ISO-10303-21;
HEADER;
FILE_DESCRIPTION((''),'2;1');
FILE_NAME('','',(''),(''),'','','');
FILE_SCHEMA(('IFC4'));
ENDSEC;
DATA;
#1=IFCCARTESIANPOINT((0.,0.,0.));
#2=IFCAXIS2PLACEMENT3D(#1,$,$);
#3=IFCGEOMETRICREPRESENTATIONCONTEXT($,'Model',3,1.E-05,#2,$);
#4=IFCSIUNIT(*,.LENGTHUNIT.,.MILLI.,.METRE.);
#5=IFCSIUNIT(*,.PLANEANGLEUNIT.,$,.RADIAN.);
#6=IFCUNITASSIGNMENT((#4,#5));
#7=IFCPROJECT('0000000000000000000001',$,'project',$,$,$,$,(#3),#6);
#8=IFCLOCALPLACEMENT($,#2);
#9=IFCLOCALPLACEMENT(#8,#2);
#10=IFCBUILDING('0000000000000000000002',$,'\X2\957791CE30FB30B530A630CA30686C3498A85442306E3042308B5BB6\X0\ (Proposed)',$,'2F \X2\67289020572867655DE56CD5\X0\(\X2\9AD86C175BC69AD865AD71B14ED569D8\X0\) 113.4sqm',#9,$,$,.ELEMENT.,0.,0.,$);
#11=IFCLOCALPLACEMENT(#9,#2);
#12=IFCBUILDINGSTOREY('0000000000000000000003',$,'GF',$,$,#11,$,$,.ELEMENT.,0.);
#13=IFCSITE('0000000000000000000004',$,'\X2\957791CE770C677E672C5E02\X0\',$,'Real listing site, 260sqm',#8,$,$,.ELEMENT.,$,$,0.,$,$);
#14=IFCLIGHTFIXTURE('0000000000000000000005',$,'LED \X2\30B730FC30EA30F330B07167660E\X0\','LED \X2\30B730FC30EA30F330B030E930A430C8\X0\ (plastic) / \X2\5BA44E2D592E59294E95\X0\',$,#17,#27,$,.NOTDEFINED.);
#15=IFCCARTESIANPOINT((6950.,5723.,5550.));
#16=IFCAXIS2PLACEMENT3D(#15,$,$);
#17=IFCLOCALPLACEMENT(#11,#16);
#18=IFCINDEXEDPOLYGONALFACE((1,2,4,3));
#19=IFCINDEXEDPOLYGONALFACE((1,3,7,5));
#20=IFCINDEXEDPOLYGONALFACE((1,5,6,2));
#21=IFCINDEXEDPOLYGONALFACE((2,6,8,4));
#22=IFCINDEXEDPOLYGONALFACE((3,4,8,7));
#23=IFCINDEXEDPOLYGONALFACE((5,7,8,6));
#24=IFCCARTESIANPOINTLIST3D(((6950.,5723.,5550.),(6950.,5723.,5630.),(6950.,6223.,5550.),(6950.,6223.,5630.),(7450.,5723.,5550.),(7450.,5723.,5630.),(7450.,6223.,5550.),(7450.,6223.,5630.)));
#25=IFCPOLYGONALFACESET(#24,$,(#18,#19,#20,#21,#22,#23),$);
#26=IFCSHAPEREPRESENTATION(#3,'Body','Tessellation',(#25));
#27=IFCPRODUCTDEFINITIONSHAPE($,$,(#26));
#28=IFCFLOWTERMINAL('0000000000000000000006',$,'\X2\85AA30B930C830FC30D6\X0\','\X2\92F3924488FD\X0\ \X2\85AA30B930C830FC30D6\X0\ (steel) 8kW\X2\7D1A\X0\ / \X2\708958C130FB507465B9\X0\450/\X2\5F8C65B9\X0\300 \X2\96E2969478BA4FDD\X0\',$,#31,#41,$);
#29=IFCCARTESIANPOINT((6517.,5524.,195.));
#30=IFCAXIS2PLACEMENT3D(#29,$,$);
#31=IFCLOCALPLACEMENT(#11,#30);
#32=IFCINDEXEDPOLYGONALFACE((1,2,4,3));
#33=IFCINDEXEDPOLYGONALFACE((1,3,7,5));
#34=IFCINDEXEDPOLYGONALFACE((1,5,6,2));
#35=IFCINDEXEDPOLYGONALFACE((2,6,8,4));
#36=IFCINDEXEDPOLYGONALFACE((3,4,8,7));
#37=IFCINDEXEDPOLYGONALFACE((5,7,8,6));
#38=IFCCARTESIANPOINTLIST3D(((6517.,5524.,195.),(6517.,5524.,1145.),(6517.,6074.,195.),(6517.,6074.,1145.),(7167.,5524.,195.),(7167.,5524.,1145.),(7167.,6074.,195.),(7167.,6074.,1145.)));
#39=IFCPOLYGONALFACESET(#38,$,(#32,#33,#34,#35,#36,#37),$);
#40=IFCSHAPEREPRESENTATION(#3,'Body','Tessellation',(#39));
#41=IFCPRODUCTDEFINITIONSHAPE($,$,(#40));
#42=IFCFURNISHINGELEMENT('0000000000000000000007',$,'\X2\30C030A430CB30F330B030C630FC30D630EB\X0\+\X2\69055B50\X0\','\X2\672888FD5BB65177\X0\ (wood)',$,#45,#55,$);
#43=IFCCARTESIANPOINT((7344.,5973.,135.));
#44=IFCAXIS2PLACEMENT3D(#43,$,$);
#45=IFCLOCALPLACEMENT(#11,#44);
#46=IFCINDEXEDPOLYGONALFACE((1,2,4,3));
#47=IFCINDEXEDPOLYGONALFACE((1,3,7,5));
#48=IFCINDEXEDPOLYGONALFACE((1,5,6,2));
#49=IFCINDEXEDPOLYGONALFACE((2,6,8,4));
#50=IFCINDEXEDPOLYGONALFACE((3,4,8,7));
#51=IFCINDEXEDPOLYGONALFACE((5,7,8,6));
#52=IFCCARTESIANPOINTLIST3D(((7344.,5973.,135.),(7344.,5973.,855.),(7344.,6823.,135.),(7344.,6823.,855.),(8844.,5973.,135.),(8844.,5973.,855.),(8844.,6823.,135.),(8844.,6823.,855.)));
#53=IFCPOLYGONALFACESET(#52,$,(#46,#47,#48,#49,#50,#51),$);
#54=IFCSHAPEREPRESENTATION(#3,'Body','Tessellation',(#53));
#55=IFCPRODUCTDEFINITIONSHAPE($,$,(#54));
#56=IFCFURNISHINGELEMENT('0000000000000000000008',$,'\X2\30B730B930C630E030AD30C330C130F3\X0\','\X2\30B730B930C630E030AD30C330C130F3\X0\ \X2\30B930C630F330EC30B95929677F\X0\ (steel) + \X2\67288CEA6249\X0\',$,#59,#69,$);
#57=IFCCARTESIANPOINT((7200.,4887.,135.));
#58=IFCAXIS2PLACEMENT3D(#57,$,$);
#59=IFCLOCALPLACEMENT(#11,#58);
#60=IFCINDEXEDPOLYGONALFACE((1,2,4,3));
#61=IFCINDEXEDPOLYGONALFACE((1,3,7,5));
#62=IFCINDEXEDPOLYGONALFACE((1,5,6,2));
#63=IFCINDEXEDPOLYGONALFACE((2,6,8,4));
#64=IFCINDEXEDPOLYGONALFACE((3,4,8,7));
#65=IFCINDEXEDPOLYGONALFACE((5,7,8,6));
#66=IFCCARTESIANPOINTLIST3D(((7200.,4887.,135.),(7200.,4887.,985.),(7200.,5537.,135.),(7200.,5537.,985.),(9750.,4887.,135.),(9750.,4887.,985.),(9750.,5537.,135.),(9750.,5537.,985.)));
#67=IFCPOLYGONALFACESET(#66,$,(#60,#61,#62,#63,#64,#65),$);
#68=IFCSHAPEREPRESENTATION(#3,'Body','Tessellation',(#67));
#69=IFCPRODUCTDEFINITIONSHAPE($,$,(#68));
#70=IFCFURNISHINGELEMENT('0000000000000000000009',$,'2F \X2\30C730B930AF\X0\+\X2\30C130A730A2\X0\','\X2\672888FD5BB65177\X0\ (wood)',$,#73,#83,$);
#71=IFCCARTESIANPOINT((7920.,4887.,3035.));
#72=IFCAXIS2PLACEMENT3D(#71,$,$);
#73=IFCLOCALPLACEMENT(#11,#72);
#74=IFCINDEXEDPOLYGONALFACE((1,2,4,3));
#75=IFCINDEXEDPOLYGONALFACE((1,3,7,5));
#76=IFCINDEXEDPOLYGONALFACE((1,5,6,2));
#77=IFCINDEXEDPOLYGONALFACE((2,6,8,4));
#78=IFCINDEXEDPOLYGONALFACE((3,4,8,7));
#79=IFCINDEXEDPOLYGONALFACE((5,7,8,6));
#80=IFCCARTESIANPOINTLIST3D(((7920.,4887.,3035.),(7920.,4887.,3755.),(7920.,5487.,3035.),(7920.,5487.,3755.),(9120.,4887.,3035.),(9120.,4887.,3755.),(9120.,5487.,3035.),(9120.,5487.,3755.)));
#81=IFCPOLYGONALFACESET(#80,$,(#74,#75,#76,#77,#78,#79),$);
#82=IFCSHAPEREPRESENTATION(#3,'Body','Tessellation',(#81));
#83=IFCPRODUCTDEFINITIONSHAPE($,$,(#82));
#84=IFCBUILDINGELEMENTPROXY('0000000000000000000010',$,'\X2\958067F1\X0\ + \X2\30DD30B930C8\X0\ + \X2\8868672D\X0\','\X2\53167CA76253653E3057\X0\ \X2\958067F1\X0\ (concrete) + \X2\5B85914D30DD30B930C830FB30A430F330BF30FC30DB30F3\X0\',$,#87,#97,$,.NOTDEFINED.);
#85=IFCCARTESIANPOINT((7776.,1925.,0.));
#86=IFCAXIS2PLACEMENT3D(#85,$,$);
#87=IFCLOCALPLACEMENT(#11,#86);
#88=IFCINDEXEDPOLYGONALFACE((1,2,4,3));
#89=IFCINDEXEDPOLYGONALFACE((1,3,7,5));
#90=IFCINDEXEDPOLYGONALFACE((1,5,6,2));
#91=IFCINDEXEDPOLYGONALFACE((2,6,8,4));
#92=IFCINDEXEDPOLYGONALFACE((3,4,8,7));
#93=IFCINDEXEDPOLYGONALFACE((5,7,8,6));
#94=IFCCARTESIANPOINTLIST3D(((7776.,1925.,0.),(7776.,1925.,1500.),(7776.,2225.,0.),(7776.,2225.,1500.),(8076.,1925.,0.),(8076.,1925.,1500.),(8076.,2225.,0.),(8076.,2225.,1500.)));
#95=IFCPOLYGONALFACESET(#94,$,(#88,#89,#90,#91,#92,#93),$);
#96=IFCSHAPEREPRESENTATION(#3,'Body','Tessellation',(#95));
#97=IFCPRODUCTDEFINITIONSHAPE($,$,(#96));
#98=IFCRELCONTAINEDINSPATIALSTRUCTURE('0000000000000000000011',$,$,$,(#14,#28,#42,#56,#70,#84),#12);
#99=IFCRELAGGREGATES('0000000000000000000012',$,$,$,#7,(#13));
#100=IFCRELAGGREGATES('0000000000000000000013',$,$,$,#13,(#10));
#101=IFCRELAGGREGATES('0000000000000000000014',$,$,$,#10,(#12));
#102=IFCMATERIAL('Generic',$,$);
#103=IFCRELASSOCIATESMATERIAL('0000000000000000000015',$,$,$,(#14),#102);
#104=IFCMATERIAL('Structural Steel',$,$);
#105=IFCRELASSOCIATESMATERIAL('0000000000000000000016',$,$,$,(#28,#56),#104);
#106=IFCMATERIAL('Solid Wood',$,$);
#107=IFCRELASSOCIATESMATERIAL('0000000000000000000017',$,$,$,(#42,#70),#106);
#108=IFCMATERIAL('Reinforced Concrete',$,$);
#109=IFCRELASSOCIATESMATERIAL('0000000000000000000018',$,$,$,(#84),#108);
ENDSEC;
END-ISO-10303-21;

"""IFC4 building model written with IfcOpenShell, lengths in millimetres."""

from ifc_helpers import new_model, si_unit, frame, frame_2d, origin, place, context, project, spatial, rectangle, extrude, material, element, save


model = new_model("IFC4")

# Units and contexts
model_context = context("Model", 3, precision=1e-05, world=origin())
ifc_project = project(units=[si_unit("LENGTHUNIT", "METRE", prefix="MILLI"), si_unit("PLANEANGLEUNIT", "RADIAN")], contexts=[model_context])

# Site, building, storey
site_placement = place(None, origin())
site = spatial("IfcSite", under=ifc_project, at=site_placement, Name="長野県松本市", ObjectType="Real listing site, 260sqm", CompositionType="ELEMENT", RefElevation=0.0)
building_placement = place(site_placement, origin())
building = spatial("IfcBuilding", under=site, at=building_placement, Name="長野・サウナと水風呂のある家 (Proposed)", ObjectType="2F 木造在来工法(高気密高断熱仕様) 113.4sqm", CompositionType="ELEMENT", ElevationOfRefHeight=0.0, ElevationOfTerrain=0.0)
storey_placement = place(building_placement, origin())
storey = spatial("IfcBuildingStorey", under=building, at=storey_placement, Name="GF", CompositionType="ELEMENT", Elevation=0.0)

# Shared definitions
ifc_material_1 = material(Name="Solid Wood")

# Shared definitions
ifc_material_2 = material(Name="Structural Steel")

# Shared definitions
ifc_material_3 = material(Name="Reinforced Concrete")

# Shared definitions
ifc_material_4 = material(Name="Generic")

# Light fixture
light_fixture_1_placement = place(storey_placement, frame((6950.0, 5723.0, 5550.0)))
element("IfcLightFixture", 1, at=light_fixture_1_placement, inside=storey, material=ifc_material_4, Name="LED シーリング照明", Description="LED シーリングライト (plastic) / 室中央天井", PredefinedType="NOTDEFINED", context=model_context, shape_type="SweptSolid", body=[
    extrude(rectangle(XDim=500.0, YDim=500.0, at=frame_2d((250.0, 250.0))), frame((6950.0, 5723.0, 5550.0)), (0.0, 0.0, 1.0), 80.0),
])

# Flow terminal
flow_terminal_1_placement = place(storey_placement, frame((6517.0, 5524.0, 195.0)))
element("IfcFlowTerminal", 2, at=flow_terminal_1_placement, inside=storey, material=ifc_material_2, Name="薪ストーブ", Description="鋳鉄製 薪ストーブ (steel) 8kW級 / 炉壁・側方450/後方300 離隔確保", context=model_context, shape_type="SweptSolid", body=[
    extrude(rectangle(XDim=650.0, YDim=550.0, at=frame_2d((325.0, 275.0))), frame((6517.0, 5524.0, 195.0)), (0.0, 0.0, 1.0), 950.0),
])

# Furnishing elements
furnishing_1_placement = place(storey_placement, frame((7344.0, 5973.0, 135.0)))
element("IfcFurnishingElement", 3, at=furnishing_1_placement, inside=storey, material=ifc_material_1, Name="ダイニングテーブル+椅子", Description="木製家具 (wood)", context=model_context, shape_type="SweptSolid", body=[
    extrude(rectangle(XDim=1500.0, YDim=850.0, at=frame_2d((750.0, 425.0))), frame((7344.0, 5973.0, 135.0)), (0.0, 0.0, 1.0), 720.0),
])
furnishing_2_placement = place(storey_placement, frame((7200.0, 4887.0, 135.0)))
element("IfcFurnishingElement", 4, at=furnishing_2_placement, inside=storey, material=ifc_material_2, Name="システムキッチン", Description="システムキッチン ステンレス天板 (steel) + 木質扉", context=model_context, shape_type="SweptSolid", body=[
    extrude(rectangle(XDim=2550.0, YDim=650.0, at=frame_2d((1275.0, 325.0))), frame((7200.0, 4887.0, 135.0)), (0.0, 0.0, 1.0), 850.0),
])
furnishing_3_placement = place(storey_placement, frame((7920.0, 4887.0, 3035.0)))
element("IfcFurnishingElement", 5, at=furnishing_3_placement, inside=storey, material=ifc_material_1, Name="2F デスク+チェア", Description="木製家具 (wood)", context=model_context, shape_type="SweptSolid", body=[
    extrude(rectangle(XDim=1200.0, YDim=600.0, at=frame_2d((600.0, 300.0))), frame((7920.0, 4887.0, 3035.0)), (0.0, 0.0, 1.0), 720.0),
])

# Building element proxy
proxy_placement = place(storey_placement, frame((7776.0, 1925.0, 0.0)))
element("IfcBuildingElementProxy", 6, at=proxy_placement, inside=storey, material=ifc_material_3, Name="門柱 + ポスト + 表札", Description="化粧打放し 門柱 (concrete) + 宅配ポスト・インターホン", PredefinedType="NOTDEFINED", context=model_context, shape_type="SweptSolid", body=[
    extrude(rectangle(XDim=300.0, YDim=300.0, at=frame_2d((150.0, 150.0))), frame((7776.0, 1925.0, 0.0)), (0.0, 0.0, 1.0), 1500.0),
])

save(model, "model.ifc")
